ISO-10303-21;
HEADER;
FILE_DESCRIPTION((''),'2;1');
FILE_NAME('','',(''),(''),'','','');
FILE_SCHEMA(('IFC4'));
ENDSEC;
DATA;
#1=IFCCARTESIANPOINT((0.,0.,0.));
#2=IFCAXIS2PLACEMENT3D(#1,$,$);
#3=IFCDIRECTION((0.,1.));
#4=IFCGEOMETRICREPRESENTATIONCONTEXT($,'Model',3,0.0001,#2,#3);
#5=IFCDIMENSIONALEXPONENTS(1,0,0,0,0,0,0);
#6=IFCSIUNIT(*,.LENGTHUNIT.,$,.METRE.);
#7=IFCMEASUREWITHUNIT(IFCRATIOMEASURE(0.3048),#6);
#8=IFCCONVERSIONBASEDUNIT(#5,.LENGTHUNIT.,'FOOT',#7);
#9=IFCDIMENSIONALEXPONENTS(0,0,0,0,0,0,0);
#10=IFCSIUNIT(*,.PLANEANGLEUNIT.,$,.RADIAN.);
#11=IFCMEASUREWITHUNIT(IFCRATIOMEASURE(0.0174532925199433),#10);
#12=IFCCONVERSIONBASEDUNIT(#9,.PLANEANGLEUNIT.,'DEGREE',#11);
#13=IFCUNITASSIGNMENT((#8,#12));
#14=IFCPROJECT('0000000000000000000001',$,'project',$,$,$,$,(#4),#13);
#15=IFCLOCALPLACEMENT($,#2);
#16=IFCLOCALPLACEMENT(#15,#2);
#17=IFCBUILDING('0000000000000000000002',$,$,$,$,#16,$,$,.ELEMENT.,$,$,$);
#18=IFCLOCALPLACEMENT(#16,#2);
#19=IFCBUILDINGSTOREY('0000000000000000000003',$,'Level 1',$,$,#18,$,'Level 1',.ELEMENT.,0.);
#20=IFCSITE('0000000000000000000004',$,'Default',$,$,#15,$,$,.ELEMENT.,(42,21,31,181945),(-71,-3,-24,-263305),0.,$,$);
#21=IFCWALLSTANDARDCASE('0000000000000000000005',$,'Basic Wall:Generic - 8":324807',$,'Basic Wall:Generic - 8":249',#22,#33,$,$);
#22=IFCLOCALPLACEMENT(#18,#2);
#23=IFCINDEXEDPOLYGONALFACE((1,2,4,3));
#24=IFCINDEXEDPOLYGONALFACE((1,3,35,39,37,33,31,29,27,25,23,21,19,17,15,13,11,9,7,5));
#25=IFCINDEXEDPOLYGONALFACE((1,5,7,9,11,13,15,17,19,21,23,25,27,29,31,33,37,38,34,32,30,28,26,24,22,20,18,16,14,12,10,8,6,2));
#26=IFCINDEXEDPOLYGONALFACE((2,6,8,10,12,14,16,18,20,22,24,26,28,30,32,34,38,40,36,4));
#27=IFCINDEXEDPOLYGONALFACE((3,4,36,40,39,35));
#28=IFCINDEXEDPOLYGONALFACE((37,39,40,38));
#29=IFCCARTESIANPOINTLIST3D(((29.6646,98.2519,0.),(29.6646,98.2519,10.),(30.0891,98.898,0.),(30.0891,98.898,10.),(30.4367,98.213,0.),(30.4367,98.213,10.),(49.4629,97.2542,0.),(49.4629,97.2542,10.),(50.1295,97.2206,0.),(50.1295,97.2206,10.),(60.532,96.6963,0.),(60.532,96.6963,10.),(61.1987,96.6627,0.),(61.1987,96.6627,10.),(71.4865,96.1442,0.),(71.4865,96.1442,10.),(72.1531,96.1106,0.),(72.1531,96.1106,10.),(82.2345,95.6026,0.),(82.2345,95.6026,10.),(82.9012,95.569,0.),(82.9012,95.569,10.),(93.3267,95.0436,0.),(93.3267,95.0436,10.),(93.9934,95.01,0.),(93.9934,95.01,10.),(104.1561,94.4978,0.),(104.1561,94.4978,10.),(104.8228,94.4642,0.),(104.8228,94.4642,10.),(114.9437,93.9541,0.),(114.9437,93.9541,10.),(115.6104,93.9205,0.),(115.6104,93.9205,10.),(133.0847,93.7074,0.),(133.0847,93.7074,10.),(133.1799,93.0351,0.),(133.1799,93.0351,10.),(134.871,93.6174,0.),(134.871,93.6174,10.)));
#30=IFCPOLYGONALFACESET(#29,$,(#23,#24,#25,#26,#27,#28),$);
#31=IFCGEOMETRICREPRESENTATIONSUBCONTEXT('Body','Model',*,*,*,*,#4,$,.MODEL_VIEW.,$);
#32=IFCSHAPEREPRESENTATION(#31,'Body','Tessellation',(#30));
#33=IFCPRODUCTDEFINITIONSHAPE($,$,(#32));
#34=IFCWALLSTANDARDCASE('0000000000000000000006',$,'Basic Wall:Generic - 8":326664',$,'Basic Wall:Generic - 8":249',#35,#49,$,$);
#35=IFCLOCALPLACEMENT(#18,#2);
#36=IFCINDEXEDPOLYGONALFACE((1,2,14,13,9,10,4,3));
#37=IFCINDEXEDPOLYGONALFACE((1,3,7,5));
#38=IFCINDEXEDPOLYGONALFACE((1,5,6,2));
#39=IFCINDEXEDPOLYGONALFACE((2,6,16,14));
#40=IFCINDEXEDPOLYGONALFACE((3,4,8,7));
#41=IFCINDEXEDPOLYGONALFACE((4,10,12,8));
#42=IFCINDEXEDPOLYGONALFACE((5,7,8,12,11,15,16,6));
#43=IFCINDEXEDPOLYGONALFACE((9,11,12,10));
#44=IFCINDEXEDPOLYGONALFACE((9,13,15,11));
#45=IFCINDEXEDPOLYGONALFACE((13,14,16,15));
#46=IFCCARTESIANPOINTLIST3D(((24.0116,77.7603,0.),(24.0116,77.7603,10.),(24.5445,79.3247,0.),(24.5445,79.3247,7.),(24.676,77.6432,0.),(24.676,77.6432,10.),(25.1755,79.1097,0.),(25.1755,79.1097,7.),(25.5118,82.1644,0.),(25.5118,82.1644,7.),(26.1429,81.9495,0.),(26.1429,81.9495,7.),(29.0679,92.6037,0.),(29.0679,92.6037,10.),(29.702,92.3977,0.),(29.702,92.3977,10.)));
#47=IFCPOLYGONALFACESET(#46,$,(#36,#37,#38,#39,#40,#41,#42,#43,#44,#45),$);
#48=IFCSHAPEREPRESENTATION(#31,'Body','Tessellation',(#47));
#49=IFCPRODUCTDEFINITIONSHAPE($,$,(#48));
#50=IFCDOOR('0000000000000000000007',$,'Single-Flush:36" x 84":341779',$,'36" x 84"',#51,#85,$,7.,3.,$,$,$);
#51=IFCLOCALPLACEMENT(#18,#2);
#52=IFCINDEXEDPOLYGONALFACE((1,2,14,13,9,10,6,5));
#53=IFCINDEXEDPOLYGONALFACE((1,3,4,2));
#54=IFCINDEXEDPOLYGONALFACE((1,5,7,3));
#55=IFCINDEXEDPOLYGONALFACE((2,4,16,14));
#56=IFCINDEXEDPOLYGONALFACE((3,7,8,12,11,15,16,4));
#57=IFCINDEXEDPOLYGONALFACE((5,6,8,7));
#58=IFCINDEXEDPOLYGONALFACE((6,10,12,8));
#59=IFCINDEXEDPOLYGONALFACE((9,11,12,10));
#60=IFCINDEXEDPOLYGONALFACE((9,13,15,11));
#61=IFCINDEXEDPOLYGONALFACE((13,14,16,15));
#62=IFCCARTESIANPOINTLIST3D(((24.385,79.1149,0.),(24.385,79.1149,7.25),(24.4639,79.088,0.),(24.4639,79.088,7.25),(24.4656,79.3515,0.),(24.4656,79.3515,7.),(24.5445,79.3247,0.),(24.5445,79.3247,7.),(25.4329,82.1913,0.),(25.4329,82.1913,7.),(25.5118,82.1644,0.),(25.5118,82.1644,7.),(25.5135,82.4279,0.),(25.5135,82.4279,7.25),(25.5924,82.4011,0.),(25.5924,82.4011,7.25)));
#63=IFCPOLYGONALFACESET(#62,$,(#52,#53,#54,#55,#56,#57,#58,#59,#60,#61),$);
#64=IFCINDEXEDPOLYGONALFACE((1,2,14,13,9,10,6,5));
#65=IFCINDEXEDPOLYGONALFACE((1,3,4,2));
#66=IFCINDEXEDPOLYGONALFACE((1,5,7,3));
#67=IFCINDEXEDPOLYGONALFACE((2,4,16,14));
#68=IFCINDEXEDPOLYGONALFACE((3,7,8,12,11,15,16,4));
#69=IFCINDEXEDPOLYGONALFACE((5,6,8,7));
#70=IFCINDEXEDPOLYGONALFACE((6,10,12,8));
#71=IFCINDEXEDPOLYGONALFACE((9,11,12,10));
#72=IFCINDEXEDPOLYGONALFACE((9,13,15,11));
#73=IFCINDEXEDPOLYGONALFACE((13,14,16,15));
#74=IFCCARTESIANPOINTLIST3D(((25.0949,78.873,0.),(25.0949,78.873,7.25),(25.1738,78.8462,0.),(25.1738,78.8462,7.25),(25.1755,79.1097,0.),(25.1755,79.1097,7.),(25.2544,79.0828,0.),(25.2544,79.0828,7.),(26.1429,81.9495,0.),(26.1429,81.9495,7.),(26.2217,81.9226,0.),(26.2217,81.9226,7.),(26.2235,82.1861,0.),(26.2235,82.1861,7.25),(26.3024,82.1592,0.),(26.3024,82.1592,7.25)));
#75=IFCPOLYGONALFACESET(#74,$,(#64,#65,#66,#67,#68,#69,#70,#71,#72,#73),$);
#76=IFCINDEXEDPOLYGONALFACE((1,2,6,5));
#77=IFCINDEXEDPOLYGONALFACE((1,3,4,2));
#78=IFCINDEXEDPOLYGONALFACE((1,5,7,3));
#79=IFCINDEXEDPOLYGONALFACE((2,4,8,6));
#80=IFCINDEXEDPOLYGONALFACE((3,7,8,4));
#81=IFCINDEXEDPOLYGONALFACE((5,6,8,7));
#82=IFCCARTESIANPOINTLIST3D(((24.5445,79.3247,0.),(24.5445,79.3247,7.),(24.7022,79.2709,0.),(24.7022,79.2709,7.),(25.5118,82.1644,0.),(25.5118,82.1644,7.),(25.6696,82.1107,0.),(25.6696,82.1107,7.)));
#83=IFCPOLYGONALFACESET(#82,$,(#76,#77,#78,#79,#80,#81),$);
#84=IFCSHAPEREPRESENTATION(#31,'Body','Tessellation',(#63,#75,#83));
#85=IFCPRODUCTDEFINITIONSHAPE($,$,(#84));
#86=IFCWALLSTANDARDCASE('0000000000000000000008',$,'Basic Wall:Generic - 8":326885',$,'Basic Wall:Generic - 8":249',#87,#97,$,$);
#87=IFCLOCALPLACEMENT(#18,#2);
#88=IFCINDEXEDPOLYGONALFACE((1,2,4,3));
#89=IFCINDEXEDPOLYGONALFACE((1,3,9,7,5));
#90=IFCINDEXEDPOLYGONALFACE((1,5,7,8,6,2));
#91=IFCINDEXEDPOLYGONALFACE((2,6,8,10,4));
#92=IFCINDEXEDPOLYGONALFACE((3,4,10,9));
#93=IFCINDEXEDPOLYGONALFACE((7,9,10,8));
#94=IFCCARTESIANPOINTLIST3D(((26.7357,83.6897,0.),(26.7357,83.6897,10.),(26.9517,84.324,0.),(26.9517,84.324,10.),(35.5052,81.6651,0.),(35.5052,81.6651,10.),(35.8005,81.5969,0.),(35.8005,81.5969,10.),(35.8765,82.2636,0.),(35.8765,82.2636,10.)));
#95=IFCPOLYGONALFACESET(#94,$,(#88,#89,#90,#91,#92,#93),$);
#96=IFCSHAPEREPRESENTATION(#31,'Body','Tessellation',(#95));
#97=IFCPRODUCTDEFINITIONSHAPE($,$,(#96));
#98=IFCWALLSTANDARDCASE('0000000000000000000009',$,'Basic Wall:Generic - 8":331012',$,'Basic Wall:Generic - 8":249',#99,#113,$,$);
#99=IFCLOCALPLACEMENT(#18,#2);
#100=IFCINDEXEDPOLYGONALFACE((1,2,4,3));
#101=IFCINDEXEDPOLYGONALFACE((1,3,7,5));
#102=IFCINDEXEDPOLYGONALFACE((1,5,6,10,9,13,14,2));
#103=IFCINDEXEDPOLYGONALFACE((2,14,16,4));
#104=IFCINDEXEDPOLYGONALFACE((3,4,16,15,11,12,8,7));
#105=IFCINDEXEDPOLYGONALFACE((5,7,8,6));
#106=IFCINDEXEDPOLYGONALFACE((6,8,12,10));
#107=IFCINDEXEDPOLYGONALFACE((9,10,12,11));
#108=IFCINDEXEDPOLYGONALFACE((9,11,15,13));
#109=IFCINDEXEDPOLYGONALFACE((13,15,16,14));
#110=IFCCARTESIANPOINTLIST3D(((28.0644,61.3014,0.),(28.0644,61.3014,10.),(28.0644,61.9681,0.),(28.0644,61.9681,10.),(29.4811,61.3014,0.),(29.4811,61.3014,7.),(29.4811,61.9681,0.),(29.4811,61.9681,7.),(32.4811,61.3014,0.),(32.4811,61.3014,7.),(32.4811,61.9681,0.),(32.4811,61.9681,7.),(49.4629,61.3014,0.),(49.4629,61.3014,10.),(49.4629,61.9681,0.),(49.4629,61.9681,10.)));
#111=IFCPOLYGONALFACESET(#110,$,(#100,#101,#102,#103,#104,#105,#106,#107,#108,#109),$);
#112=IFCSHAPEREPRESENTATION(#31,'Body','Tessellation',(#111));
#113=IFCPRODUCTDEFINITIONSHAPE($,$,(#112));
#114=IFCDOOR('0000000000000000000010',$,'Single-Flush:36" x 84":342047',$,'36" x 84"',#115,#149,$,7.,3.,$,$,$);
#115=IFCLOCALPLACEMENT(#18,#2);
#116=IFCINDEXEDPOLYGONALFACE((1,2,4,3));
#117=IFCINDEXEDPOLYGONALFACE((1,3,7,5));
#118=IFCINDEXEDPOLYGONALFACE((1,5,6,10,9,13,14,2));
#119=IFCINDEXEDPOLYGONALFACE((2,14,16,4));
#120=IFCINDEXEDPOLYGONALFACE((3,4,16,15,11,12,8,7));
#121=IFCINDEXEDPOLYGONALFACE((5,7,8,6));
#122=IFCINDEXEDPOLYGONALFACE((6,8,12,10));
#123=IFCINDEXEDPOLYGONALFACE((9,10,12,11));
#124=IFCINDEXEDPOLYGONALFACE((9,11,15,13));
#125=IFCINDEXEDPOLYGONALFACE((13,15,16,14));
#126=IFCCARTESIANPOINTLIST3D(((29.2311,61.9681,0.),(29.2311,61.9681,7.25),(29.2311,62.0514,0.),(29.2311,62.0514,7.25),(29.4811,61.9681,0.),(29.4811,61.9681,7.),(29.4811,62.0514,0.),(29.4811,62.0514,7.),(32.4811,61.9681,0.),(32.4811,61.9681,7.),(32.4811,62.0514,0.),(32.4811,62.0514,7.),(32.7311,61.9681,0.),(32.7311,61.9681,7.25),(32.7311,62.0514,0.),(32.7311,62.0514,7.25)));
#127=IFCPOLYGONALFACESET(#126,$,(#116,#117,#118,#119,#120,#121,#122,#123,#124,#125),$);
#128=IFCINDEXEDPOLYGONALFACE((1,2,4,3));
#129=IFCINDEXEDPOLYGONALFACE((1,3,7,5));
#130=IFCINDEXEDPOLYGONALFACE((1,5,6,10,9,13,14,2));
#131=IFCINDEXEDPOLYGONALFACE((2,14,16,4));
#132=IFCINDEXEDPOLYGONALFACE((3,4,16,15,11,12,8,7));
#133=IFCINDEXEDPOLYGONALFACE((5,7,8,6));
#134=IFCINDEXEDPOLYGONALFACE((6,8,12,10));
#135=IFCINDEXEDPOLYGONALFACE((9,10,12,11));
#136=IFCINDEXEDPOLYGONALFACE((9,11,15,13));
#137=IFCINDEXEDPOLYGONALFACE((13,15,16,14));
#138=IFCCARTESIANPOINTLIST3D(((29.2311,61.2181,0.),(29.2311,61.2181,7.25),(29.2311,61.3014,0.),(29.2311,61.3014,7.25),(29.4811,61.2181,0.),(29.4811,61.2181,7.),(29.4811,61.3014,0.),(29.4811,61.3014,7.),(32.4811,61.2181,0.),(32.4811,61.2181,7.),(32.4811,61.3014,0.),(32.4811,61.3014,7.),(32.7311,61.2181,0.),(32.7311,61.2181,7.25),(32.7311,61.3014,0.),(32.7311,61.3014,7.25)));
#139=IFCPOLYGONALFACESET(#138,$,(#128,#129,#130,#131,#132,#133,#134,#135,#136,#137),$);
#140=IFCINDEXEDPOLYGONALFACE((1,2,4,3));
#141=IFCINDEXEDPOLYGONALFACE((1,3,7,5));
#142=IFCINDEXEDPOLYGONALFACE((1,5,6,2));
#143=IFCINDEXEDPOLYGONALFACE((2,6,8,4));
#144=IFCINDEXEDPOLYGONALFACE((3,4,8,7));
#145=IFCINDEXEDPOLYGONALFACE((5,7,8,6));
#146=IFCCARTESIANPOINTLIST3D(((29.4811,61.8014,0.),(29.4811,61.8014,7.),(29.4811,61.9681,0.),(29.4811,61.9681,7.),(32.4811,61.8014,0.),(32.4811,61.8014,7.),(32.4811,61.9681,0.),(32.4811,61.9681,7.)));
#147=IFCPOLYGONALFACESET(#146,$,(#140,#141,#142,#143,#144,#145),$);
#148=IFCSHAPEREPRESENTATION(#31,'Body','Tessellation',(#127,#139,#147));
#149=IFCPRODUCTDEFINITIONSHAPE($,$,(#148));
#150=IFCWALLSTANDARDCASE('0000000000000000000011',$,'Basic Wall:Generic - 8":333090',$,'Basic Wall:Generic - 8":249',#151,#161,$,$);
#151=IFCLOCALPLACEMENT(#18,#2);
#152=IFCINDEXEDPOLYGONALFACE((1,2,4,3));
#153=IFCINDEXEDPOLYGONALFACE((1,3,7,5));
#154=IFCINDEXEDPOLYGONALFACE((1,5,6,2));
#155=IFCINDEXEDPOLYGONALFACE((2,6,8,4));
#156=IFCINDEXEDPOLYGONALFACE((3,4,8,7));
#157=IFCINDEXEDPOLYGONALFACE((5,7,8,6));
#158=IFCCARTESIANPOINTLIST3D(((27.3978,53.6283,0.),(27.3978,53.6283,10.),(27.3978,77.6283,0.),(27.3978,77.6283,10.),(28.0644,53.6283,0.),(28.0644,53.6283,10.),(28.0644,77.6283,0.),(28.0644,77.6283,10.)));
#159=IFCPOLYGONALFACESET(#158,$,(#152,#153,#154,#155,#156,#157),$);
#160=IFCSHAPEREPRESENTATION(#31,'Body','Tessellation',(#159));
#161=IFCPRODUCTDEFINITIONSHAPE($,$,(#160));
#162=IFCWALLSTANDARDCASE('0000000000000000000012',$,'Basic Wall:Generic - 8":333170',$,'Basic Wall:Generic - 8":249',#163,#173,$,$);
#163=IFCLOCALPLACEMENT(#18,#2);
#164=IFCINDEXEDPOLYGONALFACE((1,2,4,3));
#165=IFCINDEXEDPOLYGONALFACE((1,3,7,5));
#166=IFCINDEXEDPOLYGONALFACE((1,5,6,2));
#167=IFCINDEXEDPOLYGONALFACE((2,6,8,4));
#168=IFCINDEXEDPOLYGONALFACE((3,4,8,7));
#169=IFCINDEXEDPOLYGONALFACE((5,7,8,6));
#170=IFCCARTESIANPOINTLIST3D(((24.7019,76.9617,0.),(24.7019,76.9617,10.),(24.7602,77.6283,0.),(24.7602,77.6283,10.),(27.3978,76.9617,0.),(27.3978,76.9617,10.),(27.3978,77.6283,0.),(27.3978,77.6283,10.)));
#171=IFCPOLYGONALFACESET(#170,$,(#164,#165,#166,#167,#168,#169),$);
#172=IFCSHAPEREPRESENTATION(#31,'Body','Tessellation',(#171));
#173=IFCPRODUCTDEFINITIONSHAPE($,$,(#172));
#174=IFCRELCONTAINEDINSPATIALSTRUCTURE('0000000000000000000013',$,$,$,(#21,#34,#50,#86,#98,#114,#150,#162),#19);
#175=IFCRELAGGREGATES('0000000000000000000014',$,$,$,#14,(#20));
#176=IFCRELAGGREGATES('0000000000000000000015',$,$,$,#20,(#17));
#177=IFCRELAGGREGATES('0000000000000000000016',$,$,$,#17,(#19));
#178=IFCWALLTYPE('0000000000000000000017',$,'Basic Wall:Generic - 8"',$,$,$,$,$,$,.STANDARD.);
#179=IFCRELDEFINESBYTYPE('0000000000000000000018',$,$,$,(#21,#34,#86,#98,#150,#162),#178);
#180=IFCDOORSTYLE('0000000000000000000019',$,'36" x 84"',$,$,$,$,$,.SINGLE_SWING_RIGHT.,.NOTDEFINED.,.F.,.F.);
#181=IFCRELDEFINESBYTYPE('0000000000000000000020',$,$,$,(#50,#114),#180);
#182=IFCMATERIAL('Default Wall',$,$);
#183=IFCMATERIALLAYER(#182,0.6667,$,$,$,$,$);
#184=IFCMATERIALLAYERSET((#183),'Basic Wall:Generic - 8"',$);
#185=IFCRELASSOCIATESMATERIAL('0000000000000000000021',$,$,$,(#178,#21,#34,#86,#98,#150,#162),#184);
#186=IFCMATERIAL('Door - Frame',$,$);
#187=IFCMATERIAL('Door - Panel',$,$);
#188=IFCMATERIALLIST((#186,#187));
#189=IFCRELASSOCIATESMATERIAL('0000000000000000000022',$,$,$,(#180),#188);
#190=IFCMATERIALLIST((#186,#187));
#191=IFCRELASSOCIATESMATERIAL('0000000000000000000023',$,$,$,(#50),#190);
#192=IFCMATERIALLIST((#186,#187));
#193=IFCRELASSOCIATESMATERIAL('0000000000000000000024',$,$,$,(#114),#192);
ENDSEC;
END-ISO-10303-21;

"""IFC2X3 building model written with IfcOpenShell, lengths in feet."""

from ifc_helpers import new_model, entity, si_unit, converted_unit, direction, frame, frame_2d, origin, place, context, subcontext, project, spatial, polyline, rectangle, outline, extrude, source, transform, mapped, material, material_list, layer, layer_set, layer_usage, type_object, type_shapes, element, fill, save


model = new_model("IFC2X3")

# Units and contexts
model_context = context("Model", 3, precision=0.0001, world=origin(), true_north=direction((0.0, 1.0)))
body_context = subcontext(model_context, "Body", "Model", "MODEL_VIEW")
ifc_project = project(units=[converted_unit("LENGTHUNIT", "FOOT", entity("IfcRatioMeasure", 0.3048), si_unit("LENGTHUNIT", "METRE"), dimensions=[1, 0, 0, 0, 0, 0, 0]), converted_unit("PLANEANGLEUNIT", "DEGREE", entity("IfcRatioMeasure", 0.0174532925199433), si_unit("PLANEANGLEUNIT", "RADIAN"), dimensions=[0, 0, 0, 0, 0, 0, 0])], contexts=[model_context])

# Site, building, storey
site_placement = place(None, origin())
site = spatial("IfcSite", under=ifc_project, at=site_placement, Name="Default", CompositionType="ELEMENT", RefLatitude=(42, 21, 31, 181945), RefLongitude=(-71, -3, -24, -263305), RefElevation=0.0)
building_placement = place(site_placement, origin())
building = spatial("IfcBuilding", under=site, at=building_placement, CompositionType="ELEMENT")
storey_placement = place(building_placement, origin())
storey = spatial("IfcBuildingStorey", under=building, at=storey_placement, Name="Level 1", LongName="Level 1", CompositionType="ELEMENT", Elevation=0.0)

# Wall
ifc_material_1 = material(Name="Default Wall")
ifc_layer_1 = layer(ifc_material_1, 0.6667)
ifc_layer_set_1 = layer_set([ifc_layer_1], Name="Basic Wall:Generic - 8\"")
ifc_layer_usage_1 = layer_usage(ifc_layer_set_1, "AXIS2", "NEGATIVE", 0.3333)
wall_type_1 = type_object("IfcWallType", Name="Basic Wall:Generic - 8\"", PredefinedType="STANDARD", material=ifc_layer_set_1)
wall_1_placement = place(storey_placement, frame((29.6814, 98.5848, 0.0), z_axis=(0.0, 0.0, 1.0), x_axis=(0.998733, -0.050333, 0.0)))
element("IfcWallStandardCase", 1, at=wall_1_placement, inside=storey, type_object=wall_type_1, material=ifc_layer_usage_1, Name="Basic Wall:Generic - 8\":324807", ObjectType="Basic Wall:Generic - 8\":249", context=body_context, shape_type="SweptSolid", body=[
    extrude(outline(polyline([(103.6467, -0.3333), (105.3064, 0.3333), (103.5178, 0.3333), (0.3914, 0.3333), (0.0, -0.3333), (0.7731, -0.3333), (19.8234, -0.3333), (20.4909, -0.3333), (30.9066, -0.3333), (31.5741, -0.3333), (41.875, -0.3333), (42.5425, -0.3333), (52.6366, -0.3333), (53.3041, -0.3333), (63.743, -0.3333), (64.4105, -0.3333), (74.586, -0.3333), (75.2536, -0.3333), (85.3874, -0.3333), (86.0549, -0.3333), (103.6467, -0.3333)])), origin(), (0.0, 0.0, 1.0), 10.0),
])

# Wall, opening, door
ifc_material_2 = material(Name="Door - Frame")
ifc_material_3 = material(Name="Door - Panel")
ifc_material_list_1 = material_list([ifc_material_2, ifc_material_3])
door_style = type_object("IfcDoorStyle", Name="36\" x 84\"", ConstructionType="NOTDEFINED", OperationType="SINGLE_SWING_RIGHT", ParameterTakesPrecedence=False, Sizeable=False, material=ifc_material_list_1)
shared_shape = source(origin(), body_context, "Body", "SweptSolid", [
    extrude(outline(polyline([(-1.75, -3.6875), (1.75, -3.6875), (1.75, 3.5625), (1.5, 3.5625), (1.5, -3.4375), (-1.5, -3.4375), (-1.5, 3.5625), (-1.75, 3.5625), (-1.75, -3.6875)])), frame((1.5, 0.6667, 3.5625), z_axis=(0.0, 1.0, 0.0), x_axis=(1.0, 0.0, 0.0)), (0.0, 0.0, 1.0), 0.0833),
    extrude(outline(polyline([(-3.6875, -1.75), (3.5625, -1.75), (3.5625, -1.5), (-3.4375, -1.5), (-3.4375, 1.5), (3.5625, 1.5), (3.5625, 1.75), (-3.6875, 1.75), (-3.6875, -1.75)])), frame((1.5, -0.0833, 3.5625), z_axis=(0.0, 1.0, 0.0), x_axis=(0.0, 0.0, -1.0)), (0.0, 0.0, 1.0), 0.0833),
    extrude(rectangle(XDim=0.1667, YDim=3.0, at=frame_2d((0.0, 0.0), x_axis=(1.0, 0.0))), frame((1.5, 0.5833, 0.0), z_axis=(0.0, 0.0, 1.0), x_axis=(0.0, 1.0, 0.0)), (0.0, 0.0, 1.0), 7.0),
])
type_shapes(door_style, [shared_shape])
ifc_layer_usage_2 = layer_usage(ifc_layer_set_1, "AXIS2", "NEGATIVE", 0.3333)
wall_2_placement = place(storey_placement, frame((29.3865, 92.5052, 0.0), z_axis=(0.0, 0.0, 1.0), x_axis=(-0.322448, -0.946587, 0.0)))
wall_2 = element("IfcWallStandardCase", 2, at=wall_2_placement, inside=storey, type_object=wall_type_1, material=ifc_layer_usage_2, Name="Basic Wall:Generic - 8\":326664", ObjectType="Basic Wall:Generic - 8\":249", context=body_context, shape_type="SweptSolid", body=[
    extrude(outline(polyline([(0.0094, -0.3333), (15.6904, -0.3333), (15.5871, 0.3333), (9.1994, 0.3333), (8.5293, 0.3333), (0.0, 0.3333), (0.0094, -0.3333)])), origin(), (0.0, 0.0, 1.0), 10.0),
])
opening_1_placement = place(wall_2_placement, frame((14.0378, 0.3333, 0.0)))
opening_1 = element("IfcOpeningElement", 3, at=opening_1_placement, cuts=wall_2, ObjectType="Opening", context=body_context, shape_type="SweptSolid", body=[
    extrude(rectangle(XDim=3.0, YDim=7.0, at=frame_2d((3.5, 1.5), x_axis=(0.0, 1.0))), frame((0.0, 0.0, 0.0), z_axis=(0.0, -1.0, 0.0), x_axis=(0.0, 0.0, 1.0)), (0.0, 0.0, 1.0), 0.6667),
])
ifc_material_list_2 = material_list([ifc_material_2, ifc_material_3])
door_1_placement = place(opening_1_placement, frame((0.0, 0.0, 0.0), z_axis=(0.0, 0.0, 1.0), x_axis=(-1.0, 0.0, 0.0)))
door_1 = element("IfcDoor", 4, at=door_1_placement, inside=storey, type_object=door_style, material=ifc_material_list_2, Name="Single-Flush:36\" x 84\":341779", ObjectType="36\" x 84\"", OverallHeight=7.0, OverallWidth=3.0, context=body_context, shape_type="MappedRepresentation", body=[
    mapped(shared_shape, transform((0.0, 0.0, 0.0), scale=1.0)),
])
fill(opening_1, door_1)

# Wall
ifc_layer_usage_3 = layer_usage(ifc_layer_set_1, "AXIS2", "NEGATIVE", 0.3333)
wall_3_placement = place(storey_placement, frame((26.8106, 84.0145, 0.0), z_axis=(0.0, 0.0, 1.0), x_axis=(0.97437, -0.224951, 0.0)))
element("IfcWallStandardCase", 5, at=wall_3_placement, inside=storey, type_object=wall_type_1, material=ifc_layer_usage_3, Name="Basic Wall:Generic - 8\":326885", ObjectType="Basic Wall:Generic - 8\":249", context=body_context, shape_type="SweptSolid", body=[
    extrude(outline(polyline([(9.3033, -0.3333), (9.2273, 0.3333), (0.0678, 0.3333), (0.0, -0.3333), (9.0002, -0.3333), (9.3033, -0.3333)])), origin(), (0.0, 0.0, 1.0), 10.0),
])

# Wall, opening, door
ifc_layer_usage_4 = layer_usage(ifc_layer_set_1, "AXIS2", "NEGATIVE", 0.3333)
wall_4_placement = place(storey_placement, frame((28.0644, 61.6348, 0.0)))
wall_4 = element("IfcWallStandardCase", 6, at=wall_4_placement, inside=storey, type_object=wall_type_1, material=ifc_layer_usage_4, Name="Basic Wall:Generic - 8\":331012", ObjectType="Basic Wall:Generic - 8\":249", context=body_context, shape_type="SweptSolid", body=[
    extrude(rectangle(XDim=21.3985, YDim=0.6667, at=frame_2d((10.6992, 0.0), x_axis=(-1.0, 0.0))), origin(), (0.0, 0.0, 1.0), 10.0),
])
opening_2_placement = place(wall_4_placement, frame((1.4167, -0.3333, 0.0)))
opening_2 = element("IfcOpeningElement", 7, at=opening_2_placement, cuts=wall_4, ObjectType="Opening", context=body_context, shape_type="SweptSolid", body=[
    extrude(rectangle(XDim=3.0, YDim=7.0, at=frame_2d((3.5, 1.5), x_axis=(0.0, 1.0))), frame((0.0, 0.0, 0.0), z_axis=(0.0, 1.0, 0.0), x_axis=(0.0, 0.0, 1.0)), (0.0, 0.0, 1.0), 0.6667),
])
ifc_material_list_3 = material_list([ifc_material_2, ifc_material_3])
door_2_placement = place(opening_2_placement, origin())
door_2 = element("IfcDoor", 8, at=door_2_placement, inside=storey, type_object=door_style, material=ifc_material_list_3, Name="Single-Flush:36\" x 84\":342047", ObjectType="36\" x 84\"", OverallHeight=7.0, OverallWidth=3.0, context=body_context, shape_type="MappedRepresentation", body=[
    mapped(shared_shape, transform((0.0, 0.0, 0.0), scale=1.0)),
])
fill(opening_2, door_2)

# Walls
ifc_layer_usage_5 = layer_usage(ifc_layer_set_1, "AXIS2", "NEGATIVE", 0.3333)
wall_5_placement = place(storey_placement, frame((27.7311, 53.6283, 0.0), z_axis=(0.0, 0.0, 1.0), x_axis=(0.0, 1.0, 0.0)))
element("IfcWallStandardCase", 9, at=wall_5_placement, inside=storey, type_object=wall_type_1, material=ifc_layer_usage_5, Name="Basic Wall:Generic - 8\":333090", ObjectType="Basic Wall:Generic - 8\":249", context=body_context, shape_type="SweptSolid", body=[
    extrude(rectangle(XDim=24.0, YDim=0.6667, at=frame_2d((12.0, 0.0), x_axis=(-1.0, 0.0))), origin(), (0.0, 0.0, 1.0), 10.0),
])
ifc_layer_usage_6 = layer_usage(ifc_layer_set_1, "AXIS2", "NEGATIVE", 0.3333)
wall_6_placement = place(storey_placement, frame((27.3978, 77.295, 0.0), z_axis=(0.0, 0.0, 1.0), x_axis=(-1.0, 0.0, 0.0)))
element("IfcWallStandardCase", 10, at=wall_6_placement, inside=storey, type_object=wall_type_1, material=ifc_layer_usage_6, Name="Basic Wall:Generic - 8\":333170", ObjectType="Basic Wall:Generic - 8\":249", context=body_context, shape_type="SweptSolid", body=[
    extrude(outline(polyline([(2.6375, -0.3333), (2.6958, 0.3333), (0.0, 0.3333), (0.0, -0.3333), (2.6375, -0.3333)])), origin(), (0.0, 0.0, 1.0), 10.0),
])

save(model, "model.ifc")
